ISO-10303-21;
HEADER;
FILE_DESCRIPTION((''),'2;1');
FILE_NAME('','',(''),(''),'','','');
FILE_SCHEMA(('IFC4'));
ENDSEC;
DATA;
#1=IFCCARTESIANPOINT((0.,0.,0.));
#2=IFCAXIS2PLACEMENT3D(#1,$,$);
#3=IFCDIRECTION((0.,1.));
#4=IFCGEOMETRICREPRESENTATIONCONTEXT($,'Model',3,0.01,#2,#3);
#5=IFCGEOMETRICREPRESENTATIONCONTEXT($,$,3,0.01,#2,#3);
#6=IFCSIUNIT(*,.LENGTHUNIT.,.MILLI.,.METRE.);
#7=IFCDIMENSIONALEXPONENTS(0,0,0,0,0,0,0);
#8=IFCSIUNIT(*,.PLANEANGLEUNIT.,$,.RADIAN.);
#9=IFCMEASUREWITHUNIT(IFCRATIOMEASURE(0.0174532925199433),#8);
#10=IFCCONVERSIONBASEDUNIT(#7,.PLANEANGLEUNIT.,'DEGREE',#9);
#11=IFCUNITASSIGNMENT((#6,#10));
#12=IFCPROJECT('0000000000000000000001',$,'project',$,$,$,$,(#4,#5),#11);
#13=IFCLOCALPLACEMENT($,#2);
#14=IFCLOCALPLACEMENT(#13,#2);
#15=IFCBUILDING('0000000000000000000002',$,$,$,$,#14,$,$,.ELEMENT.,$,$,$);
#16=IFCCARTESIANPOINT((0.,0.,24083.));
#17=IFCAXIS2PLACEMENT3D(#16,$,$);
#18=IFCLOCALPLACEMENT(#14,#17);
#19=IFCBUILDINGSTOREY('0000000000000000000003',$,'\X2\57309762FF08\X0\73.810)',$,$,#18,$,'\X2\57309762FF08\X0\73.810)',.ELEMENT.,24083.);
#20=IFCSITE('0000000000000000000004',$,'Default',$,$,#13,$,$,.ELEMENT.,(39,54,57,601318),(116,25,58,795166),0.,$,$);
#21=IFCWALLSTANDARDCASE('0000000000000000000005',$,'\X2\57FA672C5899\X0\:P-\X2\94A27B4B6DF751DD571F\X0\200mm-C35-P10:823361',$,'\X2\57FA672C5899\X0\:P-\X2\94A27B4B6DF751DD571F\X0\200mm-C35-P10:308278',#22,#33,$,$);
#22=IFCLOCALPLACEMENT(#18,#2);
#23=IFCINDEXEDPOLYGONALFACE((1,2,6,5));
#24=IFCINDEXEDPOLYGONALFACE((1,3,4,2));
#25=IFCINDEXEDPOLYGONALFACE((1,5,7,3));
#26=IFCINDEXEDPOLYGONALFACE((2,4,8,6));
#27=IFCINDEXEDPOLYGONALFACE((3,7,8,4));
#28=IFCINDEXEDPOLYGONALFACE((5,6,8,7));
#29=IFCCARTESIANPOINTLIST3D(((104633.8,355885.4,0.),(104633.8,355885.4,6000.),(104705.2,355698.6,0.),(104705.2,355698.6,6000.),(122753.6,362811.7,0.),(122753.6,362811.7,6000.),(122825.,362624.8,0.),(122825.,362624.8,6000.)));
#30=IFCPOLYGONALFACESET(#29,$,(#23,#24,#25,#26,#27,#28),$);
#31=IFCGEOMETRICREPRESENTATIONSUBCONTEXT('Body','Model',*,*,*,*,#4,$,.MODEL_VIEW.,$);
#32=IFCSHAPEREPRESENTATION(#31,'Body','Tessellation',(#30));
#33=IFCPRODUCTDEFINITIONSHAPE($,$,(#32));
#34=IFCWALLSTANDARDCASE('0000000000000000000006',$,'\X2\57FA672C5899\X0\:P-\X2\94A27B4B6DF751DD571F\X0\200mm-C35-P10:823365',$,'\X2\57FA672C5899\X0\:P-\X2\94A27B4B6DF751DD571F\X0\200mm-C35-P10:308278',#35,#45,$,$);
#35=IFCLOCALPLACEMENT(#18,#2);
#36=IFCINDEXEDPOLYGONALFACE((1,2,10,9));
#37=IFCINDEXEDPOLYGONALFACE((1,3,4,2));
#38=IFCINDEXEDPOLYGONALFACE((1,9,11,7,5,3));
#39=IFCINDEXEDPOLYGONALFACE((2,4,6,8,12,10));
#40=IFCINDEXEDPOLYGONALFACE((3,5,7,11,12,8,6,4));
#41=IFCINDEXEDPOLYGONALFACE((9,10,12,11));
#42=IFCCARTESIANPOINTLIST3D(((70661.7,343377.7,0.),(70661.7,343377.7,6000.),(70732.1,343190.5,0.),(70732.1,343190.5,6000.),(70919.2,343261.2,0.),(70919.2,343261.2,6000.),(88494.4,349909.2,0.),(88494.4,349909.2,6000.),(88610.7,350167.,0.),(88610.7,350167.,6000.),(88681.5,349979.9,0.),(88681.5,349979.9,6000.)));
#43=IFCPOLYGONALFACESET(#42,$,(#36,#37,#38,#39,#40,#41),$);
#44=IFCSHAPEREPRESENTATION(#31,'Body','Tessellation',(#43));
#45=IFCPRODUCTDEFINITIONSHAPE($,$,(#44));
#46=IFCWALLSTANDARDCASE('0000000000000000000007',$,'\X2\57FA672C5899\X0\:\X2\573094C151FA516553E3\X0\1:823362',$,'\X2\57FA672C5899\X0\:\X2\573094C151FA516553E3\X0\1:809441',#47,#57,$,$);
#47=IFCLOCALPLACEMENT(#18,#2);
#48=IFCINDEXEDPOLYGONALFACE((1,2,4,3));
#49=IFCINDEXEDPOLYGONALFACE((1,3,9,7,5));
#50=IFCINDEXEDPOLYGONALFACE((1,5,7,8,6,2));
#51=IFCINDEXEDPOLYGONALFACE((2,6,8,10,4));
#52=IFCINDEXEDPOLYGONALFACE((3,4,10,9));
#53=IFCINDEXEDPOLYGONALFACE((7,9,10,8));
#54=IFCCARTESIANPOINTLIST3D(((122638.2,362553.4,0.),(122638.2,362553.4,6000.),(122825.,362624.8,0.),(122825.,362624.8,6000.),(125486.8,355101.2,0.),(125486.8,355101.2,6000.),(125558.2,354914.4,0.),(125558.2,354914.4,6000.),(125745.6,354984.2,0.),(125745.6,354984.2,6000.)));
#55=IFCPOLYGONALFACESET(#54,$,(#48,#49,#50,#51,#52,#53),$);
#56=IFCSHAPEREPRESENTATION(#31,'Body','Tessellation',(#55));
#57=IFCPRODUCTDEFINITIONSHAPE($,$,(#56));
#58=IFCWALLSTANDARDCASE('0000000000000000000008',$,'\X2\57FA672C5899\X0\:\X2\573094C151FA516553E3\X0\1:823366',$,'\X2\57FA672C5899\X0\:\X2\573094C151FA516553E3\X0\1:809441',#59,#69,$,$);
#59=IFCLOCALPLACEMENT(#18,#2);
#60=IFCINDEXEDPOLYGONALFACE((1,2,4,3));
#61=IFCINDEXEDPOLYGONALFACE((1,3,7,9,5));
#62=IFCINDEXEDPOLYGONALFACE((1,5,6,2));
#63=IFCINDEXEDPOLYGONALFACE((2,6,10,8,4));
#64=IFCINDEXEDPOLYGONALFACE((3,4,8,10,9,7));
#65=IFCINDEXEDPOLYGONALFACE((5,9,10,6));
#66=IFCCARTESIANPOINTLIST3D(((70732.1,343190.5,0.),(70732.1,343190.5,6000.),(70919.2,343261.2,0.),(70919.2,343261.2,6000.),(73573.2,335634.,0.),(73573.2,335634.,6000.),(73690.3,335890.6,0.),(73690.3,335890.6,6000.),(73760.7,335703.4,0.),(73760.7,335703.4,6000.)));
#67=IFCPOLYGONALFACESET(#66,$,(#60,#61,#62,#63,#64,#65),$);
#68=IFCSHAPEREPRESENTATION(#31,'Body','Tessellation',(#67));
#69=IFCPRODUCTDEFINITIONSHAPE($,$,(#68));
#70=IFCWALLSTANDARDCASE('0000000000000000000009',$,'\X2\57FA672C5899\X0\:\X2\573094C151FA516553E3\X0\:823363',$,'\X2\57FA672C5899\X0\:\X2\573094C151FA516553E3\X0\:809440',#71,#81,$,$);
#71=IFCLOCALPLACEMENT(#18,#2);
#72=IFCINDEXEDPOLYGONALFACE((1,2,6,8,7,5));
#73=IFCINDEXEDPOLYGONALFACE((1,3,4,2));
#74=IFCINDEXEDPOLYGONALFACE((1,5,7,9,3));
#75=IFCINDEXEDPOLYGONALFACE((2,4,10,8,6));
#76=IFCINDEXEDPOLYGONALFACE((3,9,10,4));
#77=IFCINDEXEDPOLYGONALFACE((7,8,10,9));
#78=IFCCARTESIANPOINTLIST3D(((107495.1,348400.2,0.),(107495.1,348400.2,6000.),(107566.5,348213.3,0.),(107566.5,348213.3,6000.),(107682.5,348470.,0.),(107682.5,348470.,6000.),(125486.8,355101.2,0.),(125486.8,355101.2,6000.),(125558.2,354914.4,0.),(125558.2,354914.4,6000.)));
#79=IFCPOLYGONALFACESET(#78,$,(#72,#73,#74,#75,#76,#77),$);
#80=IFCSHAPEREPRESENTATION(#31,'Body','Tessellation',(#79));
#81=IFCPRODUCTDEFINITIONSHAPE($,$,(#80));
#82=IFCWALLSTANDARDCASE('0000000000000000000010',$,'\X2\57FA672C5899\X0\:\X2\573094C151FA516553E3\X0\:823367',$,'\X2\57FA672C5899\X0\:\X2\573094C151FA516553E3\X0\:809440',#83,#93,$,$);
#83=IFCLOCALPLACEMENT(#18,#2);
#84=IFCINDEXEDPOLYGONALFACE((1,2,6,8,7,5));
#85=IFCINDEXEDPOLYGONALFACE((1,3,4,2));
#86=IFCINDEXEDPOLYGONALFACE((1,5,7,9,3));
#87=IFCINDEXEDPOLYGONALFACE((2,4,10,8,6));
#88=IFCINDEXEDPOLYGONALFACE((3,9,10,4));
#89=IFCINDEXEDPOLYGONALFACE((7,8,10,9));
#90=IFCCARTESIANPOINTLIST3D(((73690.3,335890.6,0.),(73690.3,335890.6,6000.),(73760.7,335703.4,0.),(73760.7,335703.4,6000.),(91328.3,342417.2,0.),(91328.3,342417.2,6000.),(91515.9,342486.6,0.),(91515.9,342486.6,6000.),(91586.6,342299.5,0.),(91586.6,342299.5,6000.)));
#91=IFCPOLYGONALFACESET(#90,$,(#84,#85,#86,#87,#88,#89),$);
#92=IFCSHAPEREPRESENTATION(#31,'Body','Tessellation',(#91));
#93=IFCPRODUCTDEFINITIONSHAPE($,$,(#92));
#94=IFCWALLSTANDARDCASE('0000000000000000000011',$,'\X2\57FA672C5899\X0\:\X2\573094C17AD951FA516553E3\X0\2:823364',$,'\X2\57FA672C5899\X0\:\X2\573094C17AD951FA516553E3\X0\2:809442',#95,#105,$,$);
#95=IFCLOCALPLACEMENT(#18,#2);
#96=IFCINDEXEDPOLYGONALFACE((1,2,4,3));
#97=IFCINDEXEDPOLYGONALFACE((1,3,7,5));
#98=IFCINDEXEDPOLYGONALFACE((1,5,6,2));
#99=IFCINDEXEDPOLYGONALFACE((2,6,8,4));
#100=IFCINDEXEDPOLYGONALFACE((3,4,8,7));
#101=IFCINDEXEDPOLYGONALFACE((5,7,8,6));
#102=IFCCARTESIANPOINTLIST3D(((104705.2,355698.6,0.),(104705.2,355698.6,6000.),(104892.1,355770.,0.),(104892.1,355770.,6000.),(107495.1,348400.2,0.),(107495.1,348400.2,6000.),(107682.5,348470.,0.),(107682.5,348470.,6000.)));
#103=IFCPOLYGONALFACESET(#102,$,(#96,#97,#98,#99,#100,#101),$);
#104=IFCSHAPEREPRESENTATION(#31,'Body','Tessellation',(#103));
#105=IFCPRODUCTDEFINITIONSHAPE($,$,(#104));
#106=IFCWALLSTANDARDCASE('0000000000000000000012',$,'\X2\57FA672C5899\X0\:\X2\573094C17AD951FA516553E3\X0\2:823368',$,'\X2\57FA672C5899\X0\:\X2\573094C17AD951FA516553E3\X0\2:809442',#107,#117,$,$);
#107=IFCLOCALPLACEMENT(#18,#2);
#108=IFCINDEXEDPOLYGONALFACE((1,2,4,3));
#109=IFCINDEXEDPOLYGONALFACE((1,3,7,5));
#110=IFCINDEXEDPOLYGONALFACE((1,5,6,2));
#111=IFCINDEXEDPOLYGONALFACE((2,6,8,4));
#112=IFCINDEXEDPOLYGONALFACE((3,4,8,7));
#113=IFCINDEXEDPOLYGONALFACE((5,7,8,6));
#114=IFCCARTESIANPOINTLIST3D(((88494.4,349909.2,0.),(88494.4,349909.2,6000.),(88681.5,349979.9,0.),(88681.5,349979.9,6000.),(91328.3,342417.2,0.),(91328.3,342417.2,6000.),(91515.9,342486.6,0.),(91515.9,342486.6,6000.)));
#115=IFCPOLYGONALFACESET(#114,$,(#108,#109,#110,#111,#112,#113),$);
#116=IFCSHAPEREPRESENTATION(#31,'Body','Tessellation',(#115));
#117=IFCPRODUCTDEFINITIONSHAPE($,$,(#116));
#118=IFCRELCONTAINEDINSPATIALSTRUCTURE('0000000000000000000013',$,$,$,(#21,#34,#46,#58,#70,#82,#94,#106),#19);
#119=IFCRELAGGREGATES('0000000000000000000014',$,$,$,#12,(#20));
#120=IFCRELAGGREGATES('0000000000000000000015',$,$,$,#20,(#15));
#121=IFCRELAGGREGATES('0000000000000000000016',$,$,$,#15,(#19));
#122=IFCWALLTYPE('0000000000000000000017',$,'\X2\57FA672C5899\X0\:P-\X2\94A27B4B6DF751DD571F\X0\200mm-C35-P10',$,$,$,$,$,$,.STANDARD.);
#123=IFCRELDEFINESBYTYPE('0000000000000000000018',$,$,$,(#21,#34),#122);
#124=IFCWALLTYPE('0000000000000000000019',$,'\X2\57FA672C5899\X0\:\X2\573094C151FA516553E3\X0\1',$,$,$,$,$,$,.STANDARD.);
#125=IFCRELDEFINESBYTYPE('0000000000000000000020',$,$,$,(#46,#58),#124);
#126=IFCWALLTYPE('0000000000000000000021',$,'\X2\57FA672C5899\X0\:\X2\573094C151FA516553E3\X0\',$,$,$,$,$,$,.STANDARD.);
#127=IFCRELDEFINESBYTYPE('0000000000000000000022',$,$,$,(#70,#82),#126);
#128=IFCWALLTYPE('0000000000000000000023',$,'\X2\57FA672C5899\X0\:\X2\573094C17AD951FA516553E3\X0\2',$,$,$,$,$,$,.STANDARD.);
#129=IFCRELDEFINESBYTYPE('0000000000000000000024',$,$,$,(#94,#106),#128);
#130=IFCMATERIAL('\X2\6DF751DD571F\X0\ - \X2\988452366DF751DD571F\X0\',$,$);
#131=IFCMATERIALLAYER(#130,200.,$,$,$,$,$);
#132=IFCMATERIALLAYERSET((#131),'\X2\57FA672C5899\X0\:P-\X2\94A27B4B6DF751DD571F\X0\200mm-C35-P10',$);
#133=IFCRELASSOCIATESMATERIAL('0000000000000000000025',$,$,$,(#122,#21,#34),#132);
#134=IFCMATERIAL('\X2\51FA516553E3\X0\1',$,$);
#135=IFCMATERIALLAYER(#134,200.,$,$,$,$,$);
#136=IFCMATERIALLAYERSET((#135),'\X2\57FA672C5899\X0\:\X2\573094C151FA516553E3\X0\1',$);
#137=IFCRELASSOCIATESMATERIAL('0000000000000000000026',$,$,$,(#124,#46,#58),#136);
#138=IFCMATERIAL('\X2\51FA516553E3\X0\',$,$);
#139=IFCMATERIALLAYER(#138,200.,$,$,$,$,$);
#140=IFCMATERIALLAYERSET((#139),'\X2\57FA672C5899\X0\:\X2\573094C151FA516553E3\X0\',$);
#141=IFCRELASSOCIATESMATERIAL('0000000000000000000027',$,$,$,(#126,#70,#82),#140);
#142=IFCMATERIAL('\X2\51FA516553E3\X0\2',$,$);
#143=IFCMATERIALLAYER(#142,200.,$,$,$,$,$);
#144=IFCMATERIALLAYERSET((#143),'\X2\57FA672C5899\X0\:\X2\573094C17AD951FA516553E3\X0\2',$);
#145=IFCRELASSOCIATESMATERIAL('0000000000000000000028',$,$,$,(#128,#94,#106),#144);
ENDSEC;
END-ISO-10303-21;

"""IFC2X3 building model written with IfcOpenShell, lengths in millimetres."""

from ifc_helpers import new_model, entity, si_unit, converted_unit, direction, frame, frame_2d, origin, place, context, subcontext, project, spatial, polyline, rectangle, outline, extrude, material, layer, layer_set, layer_usage, type_object, element, save


model = new_model("IFC2X3")

# Units and contexts
model_context = context("Model", 3, precision=0.01, world=origin(), true_north=direction((0.0, 1.0)))
context_of_model = context(None, 3, precision=0.01, world=origin(), true_north=direction((0.0, 1.0)))
body_context = subcontext(model_context, "Body", "Model", "MODEL_VIEW")
ifc_project = project(units=[si_unit("LENGTHUNIT", "METRE", prefix="MILLI"), converted_unit("PLANEANGLEUNIT", "DEGREE", entity("IfcRatioMeasure", 0.0174532925199433), si_unit("PLANEANGLEUNIT", "RADIAN"), dimensions=[0, 0, 0, 0, 0, 0, 0])], contexts=[model_context, context_of_model])

# Site, building, storey
site_placement = place(None, origin())
site = spatial("IfcSite", under=ifc_project, at=site_placement, Name="Default", CompositionType="ELEMENT", RefLatitude=(39, 54, 57, 601318), RefLongitude=(116, 25, 58, 795166), RefElevation=0.0)
building_placement = place(site_placement, origin())
building = spatial("IfcBuilding", under=site, at=building_placement, CompositionType="ELEMENT")
storey_placement = place(building_placement, frame((0.0, 0.0, 24083.0)))
storey = spatial("IfcBuildingStorey", under=building, at=storey_placement, Name="地面（73.810)", LongName="地面（73.810)", CompositionType="ELEMENT", Elevation=24083.0)

# Walls
ifc_material_1 = material(Name="混凝土 - 预制混凝土")
ifc_layer_1 = layer(ifc_material_1, 200.0)
ifc_layer_set_1 = layer_set([ifc_layer_1], Name="基本墙:P-钢筋混凝土200mm-C35-P10")
ifc_layer_usage_1 = layer_usage(ifc_layer_set_1, "AXIS2", "NEGATIVE", 100.0)
wall_type_1 = type_object("IfcWallType", Name="基本墙:P-钢筋混凝土200mm-C35-P10", PredefinedType="STANDARD", material=ifc_layer_set_1)
wall_1_placement = place(storey_placement, frame((104669.5, 355792.0, 0.0), z_axis=(0.0, 0.0, 1.0), x_axis=(0.934085, 0.35705, 0.0)))
element("IfcWallStandardCase", 1, at=wall_1_placement, inside=storey, type_object=wall_type_1, material=ifc_layer_usage_1, Name="基本墙:P-钢筋混凝土200mm-C35-P10:823361", ObjectType="基本墙:P-钢筋混凝土200mm-C35-P10:308278", context=body_context, shape_type="SweptSolid", body=[
    extrude(rectangle(XDim=19398.4, YDim=200.0, at=frame_2d((9699.2, 0.0), x_axis=(-1.0, 0.0))), origin(), (0.0, 0.0, 1.0), 6000.0),
])
ifc_layer_usage_2 = layer_usage(ifc_layer_set_1, "AXIS2", "POSITIVE", -100.0)
wall_2_placement = place(storey_placement, frame((88646.1, 350073.5, 0.0), z_axis=(0.0, 0.0, 1.0), x_axis=(-0.935324, -0.353793, 0.0)))
element("IfcWallStandardCase", 2, at=wall_2_placement, inside=storey, type_object=wall_type_1, material=ifc_layer_usage_2, Name="基本墙:P-钢筋混凝土200mm-C35-P10:823365", ObjectType="基本墙:P-钢筋混凝土200mm-C35-P10:308278", context=body_context, shape_type="SweptSolid", body=[
    extrude(outline(polyline([(19190.1, -100.0), (19190.5, 100.0), (18990.5, 100.0), (200.0, 100.0), (0.0, 100.0), (0.0, -100.0), (19190.1, -100.0)])), origin(), (0.0, 0.0, 1.0), 6000.0),
])
ifc_material_2 = material(Name="出入口1")
ifc_layer_2 = layer(ifc_material_2, 200.0)
ifc_layer_set_2 = layer_set([ifc_layer_2], Name="基本墙:地铁出入口1")
ifc_layer_usage_3 = layer_usage(ifc_layer_set_2, "AXIS2", "NEGATIVE", 100.0)
wall_type_2 = type_object("IfcWallType", Name="基本墙:地铁出入口1", PredefinedType="STANDARD", material=ifc_layer_set_2)
wall_3_placement = place(storey_placement, frame((122731.6, 362589.1, 0.0), z_axis=(0.0, 0.0, 1.0), x_axis=(0.35705, -0.934085, 0.0)))
element("IfcWallStandardCase", 3, at=wall_3_placement, inside=storey, type_object=wall_type_2, material=ifc_layer_usage_3, Name="基本墙:地铁出入口1:823362", ObjectType="基本墙:地铁出入口1:809441", context=body_context, shape_type="SweptSolid", body=[
    extrude(outline(polyline([(8178.1, -100.0), (8179.8, 100.0), (0.0, 100.0), (0.0, -100.0), (7978.1, -100.0), (8178.1, -100.0)])), origin(), (0.0, 0.0, 1.0), 6000.0),
])
ifc_layer_usage_4 = layer_usage(ifc_layer_set_2, "AXIS2", "POSITIVE", -100.0)
wall_4_placement = place(storey_placement, frame((70825.6, 343226.0, 0.0), z_axis=(0.0, 0.0, 1.0), x_axis=(0.351923, -0.936029, 0.0)))
element("IfcWallStandardCase", 4, at=wall_4_placement, inside=storey, type_object=wall_type_2, material=ifc_layer_usage_4, Name="基本墙:地铁出入口1:823366", ObjectType="基本墙:地铁出入口1:809441", context=body_context, shape_type="SweptSolid", body=[
    extrude(outline(polyline([(8073.3, -100.0), (8074.4, 100.0), (7874.4, 100.0), (0.0, 100.0), (0.4, -100.0), (8073.3, -100.0)])), origin(), (0.0, 0.0, 1.0), 6000.0),
])
ifc_material_3 = material(Name="出入口")
ifc_layer_3 = layer(ifc_material_3, 200.0)
ifc_layer_set_3 = layer_set([ifc_layer_3], Name="基本墙:地铁出入口")
ifc_layer_usage_5 = layer_usage(ifc_layer_set_3, "AXIS2", "NEGATIVE", 100.0)
wall_type_3 = type_object("IfcWallType", Name="基本墙:地铁出入口", PredefinedType="STANDARD", material=ifc_layer_set_3)
wall_5_placement = place(storey_placement, frame((125523.3, 355008.1, 0.0), z_axis=(0.0, 0.0, 1.0), x_axis=(-0.937112, -0.349028, 0.0)))
element("IfcWallStandardCase", 5, at=wall_5_placement, inside=storey, type_object=wall_type_3, material=ifc_layer_usage_5, Name="基本墙:地铁出入口:823363", ObjectType="基本墙:地铁出入口:809440", context=body_context, shape_type="SweptSolid", body=[
    extrude(outline(polyline([(19200.9, -100.0), (19199.1, 100.0), (0.0, 100.0), (1.7, -100.0), (19000.8, -100.0), (19200.9, -100.0)])), origin(), (0.0, 0.0, 1.0), 6000.0),
])
ifc_layer_usage_6 = layer_usage(ifc_layer_set_3, "AXIS2", "POSITIVE", -100.0)
wall_6_placement = place(storey_placement, frame((73725.0, 335796.8, 0.0), z_axis=(0.0, 0.0, 1.0), x_axis=(0.937853, 0.347034, 0.0)))
element("IfcWallStandardCase", 6, at=wall_6_placement, inside=storey, type_object=wall_type_3, material=ifc_layer_usage_6, Name="基本墙:地铁出入口:823367", ObjectType="基本墙:地铁出入口:809440", context=body_context, shape_type="SweptSolid", body=[
    extrude(outline(polyline([(19008.2, -100.0), (19006.8, 100.0), (18806.8, 100.0), (0.0, 100.0), (1.0, -100.0), (19008.2, -100.0)])), origin(), (0.0, 0.0, 1.0), 6000.0),
])
ifc_material_4 = material(Name="出入口2")
ifc_layer_4 = layer(ifc_material_4, 200.0)
ifc_layer_set_4 = layer_set([ifc_layer_4], Name="基本墙:地铁站出入口2")
ifc_layer_usage_7 = layer_usage(ifc_layer_set_4, "AXIS2", "NEGATIVE", 100.0)
wall_type_4 = type_object("IfcWallType", Name="基本墙:地铁站出入口2", PredefinedType="STANDARD", material=ifc_layer_set_4)
wall_7_placement = place(storey_placement, frame((107589.1, 348434.3, 0.0), z_axis=(0.0, 0.0, 1.0), x_axis=(-0.35705, 0.934085, 0.0)))
element("IfcWallStandardCase", 7, at=wall_7_placement, inside=storey, type_object=wall_type_4, material=ifc_layer_usage_7, Name="基本墙:地铁站出入口2:823364", ObjectType="基本墙:地铁站出入口2:809442", context=body_context, shape_type="SweptSolid", body=[
    extrude(outline(polyline([(7815.2, -100.0), (7815.2, 100.0), (1.7, 100.0), (0.0, -100.0), (7815.2, -100.0)])), origin(), (0.0, 0.0, 1.0), 6000.0),
])
ifc_layer_usage_8 = layer_usage(ifc_layer_set_4, "AXIS2", "POSITIVE", -100.0)
wall_8_placement = place(storey_placement, frame((91422.4, 342451.2, 0.0), z_axis=(0.0, 0.0, 1.0), x_axis=(-0.353793, 0.935324, 0.0)))
element("IfcWallStandardCase", 8, at=wall_8_placement, inside=storey, type_object=wall_type_4, material=ifc_layer_usage_8, Name="基本墙:地铁站出入口2:823368", ObjectType="基本墙:地铁站出入口2:809442", context=body_context, shape_type="SweptSolid", body=[
    extrude(outline(polyline([(8011.5, -100.0), (8011.5, 100.0), (1.4, 100.0), (0.0, -100.0), (8011.5, -100.0)])), origin(), (0.0, 0.0, 1.0), 6000.0),
])

save(model, "model.ifc")
